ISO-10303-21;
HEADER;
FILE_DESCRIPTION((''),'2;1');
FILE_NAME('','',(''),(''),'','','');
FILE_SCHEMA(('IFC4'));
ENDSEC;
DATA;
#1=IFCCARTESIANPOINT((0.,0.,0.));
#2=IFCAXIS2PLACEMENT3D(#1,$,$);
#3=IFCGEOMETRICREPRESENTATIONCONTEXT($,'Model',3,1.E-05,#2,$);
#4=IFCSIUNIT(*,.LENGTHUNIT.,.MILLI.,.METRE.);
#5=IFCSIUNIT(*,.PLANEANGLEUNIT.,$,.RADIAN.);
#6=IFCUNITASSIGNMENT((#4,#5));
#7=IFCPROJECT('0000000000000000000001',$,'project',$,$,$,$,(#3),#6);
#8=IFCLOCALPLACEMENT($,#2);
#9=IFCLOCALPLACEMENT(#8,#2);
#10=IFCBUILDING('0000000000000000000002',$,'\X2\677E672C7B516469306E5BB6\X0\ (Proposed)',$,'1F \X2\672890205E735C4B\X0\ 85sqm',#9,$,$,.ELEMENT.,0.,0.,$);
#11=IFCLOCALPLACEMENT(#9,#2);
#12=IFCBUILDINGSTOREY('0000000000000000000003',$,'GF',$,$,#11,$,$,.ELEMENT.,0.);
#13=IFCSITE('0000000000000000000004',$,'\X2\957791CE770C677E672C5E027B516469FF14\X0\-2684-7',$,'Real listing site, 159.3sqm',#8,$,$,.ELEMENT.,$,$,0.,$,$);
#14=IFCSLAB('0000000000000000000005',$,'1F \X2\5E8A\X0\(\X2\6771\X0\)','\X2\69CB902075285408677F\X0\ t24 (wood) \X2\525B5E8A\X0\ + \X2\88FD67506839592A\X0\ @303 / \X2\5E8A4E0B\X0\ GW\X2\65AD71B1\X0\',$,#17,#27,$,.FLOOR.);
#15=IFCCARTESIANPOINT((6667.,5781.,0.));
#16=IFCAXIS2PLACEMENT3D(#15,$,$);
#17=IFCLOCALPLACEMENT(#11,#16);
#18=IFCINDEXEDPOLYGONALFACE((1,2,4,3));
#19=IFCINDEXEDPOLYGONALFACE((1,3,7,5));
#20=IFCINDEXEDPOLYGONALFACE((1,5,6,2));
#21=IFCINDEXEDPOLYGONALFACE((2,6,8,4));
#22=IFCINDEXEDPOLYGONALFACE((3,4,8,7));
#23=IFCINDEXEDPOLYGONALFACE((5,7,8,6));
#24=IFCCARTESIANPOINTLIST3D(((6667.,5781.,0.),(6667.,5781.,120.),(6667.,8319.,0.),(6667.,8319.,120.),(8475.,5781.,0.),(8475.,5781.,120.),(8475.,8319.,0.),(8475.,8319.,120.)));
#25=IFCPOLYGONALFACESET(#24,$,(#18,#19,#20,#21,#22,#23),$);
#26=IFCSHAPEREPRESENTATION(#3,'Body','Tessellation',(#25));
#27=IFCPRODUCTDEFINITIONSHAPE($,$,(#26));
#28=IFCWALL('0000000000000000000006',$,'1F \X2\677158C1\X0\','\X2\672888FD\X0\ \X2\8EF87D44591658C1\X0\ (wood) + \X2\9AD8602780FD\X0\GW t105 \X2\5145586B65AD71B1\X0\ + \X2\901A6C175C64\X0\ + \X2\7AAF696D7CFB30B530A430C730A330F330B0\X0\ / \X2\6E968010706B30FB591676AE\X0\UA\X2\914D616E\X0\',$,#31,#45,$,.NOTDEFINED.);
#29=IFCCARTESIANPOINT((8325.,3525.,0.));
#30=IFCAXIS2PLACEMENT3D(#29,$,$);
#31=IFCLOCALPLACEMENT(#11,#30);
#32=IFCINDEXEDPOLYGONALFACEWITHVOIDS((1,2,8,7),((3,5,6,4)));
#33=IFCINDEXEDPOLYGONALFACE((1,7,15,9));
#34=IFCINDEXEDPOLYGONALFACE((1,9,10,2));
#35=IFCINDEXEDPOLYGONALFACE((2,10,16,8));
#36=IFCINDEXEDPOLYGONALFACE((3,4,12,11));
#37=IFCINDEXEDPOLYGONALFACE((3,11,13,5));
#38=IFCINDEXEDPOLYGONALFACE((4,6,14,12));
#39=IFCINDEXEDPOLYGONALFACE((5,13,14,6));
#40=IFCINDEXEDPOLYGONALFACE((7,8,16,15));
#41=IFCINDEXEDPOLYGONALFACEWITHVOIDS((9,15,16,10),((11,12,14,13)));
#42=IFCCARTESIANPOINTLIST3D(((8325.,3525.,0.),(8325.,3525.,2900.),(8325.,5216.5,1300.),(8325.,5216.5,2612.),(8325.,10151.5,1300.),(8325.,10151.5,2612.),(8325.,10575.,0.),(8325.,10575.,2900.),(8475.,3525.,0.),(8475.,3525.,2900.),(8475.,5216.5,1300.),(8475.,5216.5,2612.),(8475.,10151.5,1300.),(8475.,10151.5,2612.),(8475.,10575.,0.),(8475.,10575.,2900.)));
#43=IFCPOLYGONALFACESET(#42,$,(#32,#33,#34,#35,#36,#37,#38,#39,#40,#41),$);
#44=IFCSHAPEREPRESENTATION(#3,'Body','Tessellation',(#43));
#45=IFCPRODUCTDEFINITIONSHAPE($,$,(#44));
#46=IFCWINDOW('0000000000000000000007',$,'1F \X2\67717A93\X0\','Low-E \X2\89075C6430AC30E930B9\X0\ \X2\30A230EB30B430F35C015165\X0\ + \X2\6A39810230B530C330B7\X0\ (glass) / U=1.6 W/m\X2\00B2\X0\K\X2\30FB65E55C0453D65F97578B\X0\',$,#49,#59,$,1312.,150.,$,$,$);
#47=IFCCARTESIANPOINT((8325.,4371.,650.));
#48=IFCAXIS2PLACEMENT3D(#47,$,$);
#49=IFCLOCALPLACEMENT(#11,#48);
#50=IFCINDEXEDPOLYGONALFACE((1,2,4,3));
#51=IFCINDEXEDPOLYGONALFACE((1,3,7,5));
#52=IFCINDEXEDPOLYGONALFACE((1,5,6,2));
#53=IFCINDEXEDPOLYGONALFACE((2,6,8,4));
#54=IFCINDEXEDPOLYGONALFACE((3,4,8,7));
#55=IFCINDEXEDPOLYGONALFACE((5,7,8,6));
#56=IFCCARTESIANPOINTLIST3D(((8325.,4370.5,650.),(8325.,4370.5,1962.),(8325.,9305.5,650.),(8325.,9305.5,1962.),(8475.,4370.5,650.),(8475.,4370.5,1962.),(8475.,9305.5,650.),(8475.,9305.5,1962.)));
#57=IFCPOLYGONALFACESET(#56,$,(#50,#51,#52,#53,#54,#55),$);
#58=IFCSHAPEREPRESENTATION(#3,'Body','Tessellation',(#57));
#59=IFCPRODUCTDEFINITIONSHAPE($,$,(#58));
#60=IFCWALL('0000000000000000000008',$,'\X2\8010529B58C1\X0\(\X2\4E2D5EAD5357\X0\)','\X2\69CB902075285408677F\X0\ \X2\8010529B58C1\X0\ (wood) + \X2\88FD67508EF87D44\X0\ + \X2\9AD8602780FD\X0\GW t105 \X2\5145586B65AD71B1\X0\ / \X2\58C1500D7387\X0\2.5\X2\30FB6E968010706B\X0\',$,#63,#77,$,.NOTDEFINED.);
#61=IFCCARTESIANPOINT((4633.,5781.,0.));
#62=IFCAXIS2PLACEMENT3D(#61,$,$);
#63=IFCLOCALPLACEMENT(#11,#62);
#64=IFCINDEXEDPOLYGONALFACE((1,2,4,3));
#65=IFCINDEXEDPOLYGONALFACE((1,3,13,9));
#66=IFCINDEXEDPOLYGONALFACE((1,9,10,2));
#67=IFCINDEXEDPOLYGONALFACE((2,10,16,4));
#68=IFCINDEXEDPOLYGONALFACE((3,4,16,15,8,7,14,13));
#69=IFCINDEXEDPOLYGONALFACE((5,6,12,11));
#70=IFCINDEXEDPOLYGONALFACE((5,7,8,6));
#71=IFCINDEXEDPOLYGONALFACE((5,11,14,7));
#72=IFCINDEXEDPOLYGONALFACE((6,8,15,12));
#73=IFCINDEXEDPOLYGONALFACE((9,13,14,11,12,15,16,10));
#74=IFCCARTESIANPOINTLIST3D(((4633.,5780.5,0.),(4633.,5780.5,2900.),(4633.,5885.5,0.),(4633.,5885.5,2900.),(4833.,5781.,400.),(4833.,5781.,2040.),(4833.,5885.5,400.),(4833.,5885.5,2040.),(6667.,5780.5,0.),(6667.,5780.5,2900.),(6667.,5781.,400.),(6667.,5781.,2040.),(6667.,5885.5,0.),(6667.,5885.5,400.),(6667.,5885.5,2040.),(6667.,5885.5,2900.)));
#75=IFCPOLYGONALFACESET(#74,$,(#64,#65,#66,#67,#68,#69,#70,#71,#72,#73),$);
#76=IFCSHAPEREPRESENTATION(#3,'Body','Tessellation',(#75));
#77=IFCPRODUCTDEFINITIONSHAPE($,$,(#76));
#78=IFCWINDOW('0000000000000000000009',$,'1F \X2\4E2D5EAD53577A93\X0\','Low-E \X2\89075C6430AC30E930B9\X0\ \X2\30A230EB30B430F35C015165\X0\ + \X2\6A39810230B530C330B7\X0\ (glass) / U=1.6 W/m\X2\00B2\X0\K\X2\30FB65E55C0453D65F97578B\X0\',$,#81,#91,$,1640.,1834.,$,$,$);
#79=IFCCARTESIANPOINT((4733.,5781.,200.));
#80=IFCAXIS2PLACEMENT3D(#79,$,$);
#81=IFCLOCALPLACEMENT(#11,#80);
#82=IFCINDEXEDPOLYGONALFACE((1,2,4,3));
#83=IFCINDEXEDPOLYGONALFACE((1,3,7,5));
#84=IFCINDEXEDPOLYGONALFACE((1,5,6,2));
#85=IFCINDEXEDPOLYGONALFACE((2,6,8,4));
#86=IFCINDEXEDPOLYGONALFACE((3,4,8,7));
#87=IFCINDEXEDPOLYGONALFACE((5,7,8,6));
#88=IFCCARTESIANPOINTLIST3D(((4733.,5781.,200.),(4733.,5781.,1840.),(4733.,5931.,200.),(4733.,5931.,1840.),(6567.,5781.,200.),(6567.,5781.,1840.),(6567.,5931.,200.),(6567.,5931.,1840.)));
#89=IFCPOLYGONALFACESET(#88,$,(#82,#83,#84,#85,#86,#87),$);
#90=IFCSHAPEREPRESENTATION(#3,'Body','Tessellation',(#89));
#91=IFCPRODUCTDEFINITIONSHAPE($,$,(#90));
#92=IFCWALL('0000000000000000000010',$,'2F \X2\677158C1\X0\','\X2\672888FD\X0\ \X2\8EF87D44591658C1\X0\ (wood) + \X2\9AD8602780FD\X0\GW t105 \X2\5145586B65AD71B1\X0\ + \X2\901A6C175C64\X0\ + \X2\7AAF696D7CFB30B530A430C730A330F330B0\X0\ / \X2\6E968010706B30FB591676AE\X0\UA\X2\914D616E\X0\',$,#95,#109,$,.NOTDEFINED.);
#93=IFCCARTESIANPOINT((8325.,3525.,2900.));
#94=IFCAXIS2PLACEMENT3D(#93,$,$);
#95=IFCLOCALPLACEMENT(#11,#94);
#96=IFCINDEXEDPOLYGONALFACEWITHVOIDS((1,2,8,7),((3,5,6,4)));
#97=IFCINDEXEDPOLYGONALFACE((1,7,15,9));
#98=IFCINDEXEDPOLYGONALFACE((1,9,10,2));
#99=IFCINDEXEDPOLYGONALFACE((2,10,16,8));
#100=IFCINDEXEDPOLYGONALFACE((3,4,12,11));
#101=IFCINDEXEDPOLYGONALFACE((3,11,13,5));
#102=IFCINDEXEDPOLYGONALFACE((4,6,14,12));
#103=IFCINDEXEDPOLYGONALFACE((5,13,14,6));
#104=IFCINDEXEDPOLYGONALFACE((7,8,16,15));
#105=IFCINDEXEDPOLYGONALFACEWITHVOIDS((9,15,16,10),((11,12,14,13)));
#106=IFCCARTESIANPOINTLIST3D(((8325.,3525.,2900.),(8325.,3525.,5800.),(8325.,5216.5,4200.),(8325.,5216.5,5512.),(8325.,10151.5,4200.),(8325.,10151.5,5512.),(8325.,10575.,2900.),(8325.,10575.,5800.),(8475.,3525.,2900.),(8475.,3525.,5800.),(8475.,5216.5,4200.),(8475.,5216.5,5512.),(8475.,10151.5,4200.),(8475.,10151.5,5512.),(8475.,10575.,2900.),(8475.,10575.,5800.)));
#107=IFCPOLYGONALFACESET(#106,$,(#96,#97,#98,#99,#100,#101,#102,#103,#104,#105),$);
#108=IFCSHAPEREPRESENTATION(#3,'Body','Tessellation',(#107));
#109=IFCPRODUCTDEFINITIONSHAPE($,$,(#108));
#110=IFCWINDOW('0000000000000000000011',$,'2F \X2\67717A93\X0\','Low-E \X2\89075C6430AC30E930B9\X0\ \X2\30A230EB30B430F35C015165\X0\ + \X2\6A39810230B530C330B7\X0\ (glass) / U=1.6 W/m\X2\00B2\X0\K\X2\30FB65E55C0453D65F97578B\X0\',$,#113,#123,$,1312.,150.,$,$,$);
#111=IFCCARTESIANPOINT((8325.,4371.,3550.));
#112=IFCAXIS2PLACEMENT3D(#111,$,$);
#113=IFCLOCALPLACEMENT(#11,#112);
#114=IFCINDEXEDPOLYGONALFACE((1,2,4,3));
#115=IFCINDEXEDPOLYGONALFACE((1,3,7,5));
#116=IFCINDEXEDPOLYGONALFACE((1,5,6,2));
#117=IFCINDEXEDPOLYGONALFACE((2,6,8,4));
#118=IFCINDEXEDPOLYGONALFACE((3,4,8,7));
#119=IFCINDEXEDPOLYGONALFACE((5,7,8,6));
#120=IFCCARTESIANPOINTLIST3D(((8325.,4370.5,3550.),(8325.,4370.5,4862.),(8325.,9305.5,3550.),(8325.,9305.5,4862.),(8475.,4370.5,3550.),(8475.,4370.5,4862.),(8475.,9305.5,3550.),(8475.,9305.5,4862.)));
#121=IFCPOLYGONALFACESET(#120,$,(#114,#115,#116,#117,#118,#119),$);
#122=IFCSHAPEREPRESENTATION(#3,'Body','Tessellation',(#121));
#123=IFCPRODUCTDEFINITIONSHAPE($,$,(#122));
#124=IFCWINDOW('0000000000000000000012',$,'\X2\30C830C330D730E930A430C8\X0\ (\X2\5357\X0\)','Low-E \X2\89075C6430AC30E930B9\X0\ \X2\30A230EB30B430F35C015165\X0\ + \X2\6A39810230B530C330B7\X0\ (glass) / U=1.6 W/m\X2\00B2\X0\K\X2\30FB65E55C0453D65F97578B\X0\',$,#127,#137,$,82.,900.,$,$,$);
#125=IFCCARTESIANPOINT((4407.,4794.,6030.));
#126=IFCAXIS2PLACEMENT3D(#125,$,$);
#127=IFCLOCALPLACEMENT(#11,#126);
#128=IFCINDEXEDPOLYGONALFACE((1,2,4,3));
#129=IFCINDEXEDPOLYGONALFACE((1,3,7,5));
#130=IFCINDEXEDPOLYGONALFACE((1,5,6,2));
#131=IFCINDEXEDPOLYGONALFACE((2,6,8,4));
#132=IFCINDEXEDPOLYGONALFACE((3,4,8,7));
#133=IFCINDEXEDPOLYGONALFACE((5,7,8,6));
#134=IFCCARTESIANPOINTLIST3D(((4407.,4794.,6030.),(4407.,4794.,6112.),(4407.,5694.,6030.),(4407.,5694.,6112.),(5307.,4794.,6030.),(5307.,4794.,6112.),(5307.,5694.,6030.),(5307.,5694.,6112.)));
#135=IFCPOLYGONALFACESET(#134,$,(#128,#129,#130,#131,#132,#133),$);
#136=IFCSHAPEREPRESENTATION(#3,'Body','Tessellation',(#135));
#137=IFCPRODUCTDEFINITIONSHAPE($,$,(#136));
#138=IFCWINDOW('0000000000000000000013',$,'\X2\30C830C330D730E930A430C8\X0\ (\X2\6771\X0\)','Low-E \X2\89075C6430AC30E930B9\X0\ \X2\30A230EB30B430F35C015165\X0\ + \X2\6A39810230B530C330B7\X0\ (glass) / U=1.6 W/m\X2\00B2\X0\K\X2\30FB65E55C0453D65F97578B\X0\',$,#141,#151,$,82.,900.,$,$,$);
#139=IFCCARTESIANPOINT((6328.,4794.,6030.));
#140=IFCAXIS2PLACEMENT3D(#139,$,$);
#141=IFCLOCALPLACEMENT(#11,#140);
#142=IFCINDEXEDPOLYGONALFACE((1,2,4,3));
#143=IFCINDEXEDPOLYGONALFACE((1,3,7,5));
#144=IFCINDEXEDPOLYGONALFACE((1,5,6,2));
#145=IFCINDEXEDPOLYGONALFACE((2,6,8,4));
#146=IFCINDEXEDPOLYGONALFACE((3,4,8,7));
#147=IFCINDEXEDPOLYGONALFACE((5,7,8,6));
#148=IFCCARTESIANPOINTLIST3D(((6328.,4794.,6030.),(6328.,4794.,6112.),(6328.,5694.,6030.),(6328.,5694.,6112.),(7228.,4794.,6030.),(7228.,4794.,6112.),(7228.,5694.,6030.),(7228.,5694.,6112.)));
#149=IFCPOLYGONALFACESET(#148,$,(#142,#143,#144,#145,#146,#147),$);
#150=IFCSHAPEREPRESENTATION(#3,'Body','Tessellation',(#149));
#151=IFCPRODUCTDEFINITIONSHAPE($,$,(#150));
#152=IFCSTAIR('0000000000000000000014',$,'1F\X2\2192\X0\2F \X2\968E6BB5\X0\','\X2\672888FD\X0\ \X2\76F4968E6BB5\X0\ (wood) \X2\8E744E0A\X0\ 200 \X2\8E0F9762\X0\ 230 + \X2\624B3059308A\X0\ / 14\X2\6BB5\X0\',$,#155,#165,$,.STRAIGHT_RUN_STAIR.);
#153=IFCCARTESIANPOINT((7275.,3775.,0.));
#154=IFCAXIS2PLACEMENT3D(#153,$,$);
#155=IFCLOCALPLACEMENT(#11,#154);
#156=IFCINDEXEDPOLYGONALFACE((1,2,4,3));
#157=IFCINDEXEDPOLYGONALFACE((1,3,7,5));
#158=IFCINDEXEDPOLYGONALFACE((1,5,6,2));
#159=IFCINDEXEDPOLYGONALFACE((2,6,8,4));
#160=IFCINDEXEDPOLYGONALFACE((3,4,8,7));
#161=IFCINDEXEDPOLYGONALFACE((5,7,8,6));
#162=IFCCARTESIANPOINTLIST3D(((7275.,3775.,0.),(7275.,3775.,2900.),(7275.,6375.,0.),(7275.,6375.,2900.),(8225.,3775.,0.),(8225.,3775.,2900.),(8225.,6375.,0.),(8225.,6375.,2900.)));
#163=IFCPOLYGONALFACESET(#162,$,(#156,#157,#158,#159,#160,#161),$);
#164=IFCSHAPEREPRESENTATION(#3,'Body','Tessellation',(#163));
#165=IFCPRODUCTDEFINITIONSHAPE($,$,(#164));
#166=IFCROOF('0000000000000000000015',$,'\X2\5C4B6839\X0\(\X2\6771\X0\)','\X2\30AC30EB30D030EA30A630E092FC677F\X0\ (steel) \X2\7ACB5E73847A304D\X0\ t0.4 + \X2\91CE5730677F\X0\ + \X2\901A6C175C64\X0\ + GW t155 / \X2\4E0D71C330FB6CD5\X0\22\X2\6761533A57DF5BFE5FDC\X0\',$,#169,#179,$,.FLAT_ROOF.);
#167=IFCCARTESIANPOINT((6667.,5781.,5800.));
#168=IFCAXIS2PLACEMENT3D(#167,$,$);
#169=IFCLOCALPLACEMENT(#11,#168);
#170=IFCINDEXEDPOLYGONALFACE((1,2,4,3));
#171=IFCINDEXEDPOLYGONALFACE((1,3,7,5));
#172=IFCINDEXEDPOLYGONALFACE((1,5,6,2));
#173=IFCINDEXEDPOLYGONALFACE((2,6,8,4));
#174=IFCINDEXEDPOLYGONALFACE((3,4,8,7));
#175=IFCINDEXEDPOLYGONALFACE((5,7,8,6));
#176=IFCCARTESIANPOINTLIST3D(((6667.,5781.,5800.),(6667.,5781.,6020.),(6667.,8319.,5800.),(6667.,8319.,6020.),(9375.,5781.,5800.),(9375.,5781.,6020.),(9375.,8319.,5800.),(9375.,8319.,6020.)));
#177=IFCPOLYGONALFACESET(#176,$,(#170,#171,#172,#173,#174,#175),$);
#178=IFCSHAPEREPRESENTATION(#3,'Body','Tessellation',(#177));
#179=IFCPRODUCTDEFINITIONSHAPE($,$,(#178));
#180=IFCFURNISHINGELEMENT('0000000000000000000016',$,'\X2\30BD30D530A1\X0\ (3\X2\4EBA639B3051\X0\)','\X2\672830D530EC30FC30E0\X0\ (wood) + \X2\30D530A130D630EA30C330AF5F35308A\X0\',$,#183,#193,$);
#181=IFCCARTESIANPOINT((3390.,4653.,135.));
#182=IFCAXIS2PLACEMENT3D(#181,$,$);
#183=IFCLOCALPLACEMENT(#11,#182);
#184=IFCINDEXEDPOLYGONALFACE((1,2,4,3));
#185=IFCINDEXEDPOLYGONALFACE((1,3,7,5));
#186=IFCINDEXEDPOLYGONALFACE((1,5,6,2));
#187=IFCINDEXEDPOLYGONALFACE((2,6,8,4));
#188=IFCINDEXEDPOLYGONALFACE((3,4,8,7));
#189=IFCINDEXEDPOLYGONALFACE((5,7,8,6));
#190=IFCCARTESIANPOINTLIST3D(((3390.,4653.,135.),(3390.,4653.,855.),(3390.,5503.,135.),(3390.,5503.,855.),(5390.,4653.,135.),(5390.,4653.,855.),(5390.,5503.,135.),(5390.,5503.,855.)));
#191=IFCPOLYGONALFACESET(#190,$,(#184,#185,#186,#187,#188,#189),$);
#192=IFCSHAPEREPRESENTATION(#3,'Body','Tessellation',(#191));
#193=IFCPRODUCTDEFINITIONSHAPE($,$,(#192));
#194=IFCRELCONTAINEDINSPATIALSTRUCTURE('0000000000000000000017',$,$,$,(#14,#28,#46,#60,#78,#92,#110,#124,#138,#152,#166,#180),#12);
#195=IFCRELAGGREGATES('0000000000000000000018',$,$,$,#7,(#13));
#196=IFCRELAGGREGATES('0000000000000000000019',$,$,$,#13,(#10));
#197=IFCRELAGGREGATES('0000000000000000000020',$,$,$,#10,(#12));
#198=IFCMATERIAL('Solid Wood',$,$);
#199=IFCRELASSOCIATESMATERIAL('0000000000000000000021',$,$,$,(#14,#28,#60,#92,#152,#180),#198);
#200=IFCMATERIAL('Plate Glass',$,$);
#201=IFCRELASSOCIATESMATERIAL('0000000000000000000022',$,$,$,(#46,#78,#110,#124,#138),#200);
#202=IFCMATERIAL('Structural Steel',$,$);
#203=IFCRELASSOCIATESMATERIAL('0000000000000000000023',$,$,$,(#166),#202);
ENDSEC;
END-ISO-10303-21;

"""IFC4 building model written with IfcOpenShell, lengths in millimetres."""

from ifc_helpers import new_model, si_unit, frame, frame_2d, origin, place, context, project, spatial, rectangle, extrude, material, element, fill, save


model = new_model("IFC4")

# Units and contexts
model_context = context("Model", 3, precision=1e-05, world=origin())
ifc_project = project(units=[si_unit("LENGTHUNIT", "METRE", prefix="MILLI"), si_unit("PLANEANGLEUNIT", "RADIAN")], contexts=[model_context])

# Site, building, storey
site_placement = place(None, origin())
site = spatial("IfcSite", under=ifc_project, at=site_placement, Name="長野県松本市筑摩４-2684-7", ObjectType="Real listing site, 159.3sqm", CompositionType="ELEMENT", RefElevation=0.0)
building_placement = place(site_placement, origin())
building = spatial("IfcBuilding", under=site, at=building_placement, Name="松本筑摩の家 (Proposed)", ObjectType="1F 木造平屋 85sqm", CompositionType="ELEMENT", ElevationOfRefHeight=0.0, ElevationOfTerrain=0.0)
storey_placement = place(building_placement, origin())
storey = spatial("IfcBuildingStorey", under=building, at=storey_placement, Name="GF", CompositionType="ELEMENT", Elevation=0.0)

# Slab
ifc_material_1 = material(Name="Solid Wood")
slab_placement = place(storey_placement, frame((6667.0, 5781.0, 0.0)))
element("IfcSlab", 1, at=slab_placement, inside=storey, material=ifc_material_1, Name="1F 床(東)", Description="構造用合板 t24 (wood) 剛床 + 製材根太 @303 / 床下 GW断熱", PredefinedType="FLOOR", context=model_context, shape_type="SweptSolid", body=[
    extrude(rectangle(XDim=1808.0, YDim=2538.0, at=frame_2d((904.0, 1269.0))), frame((6667.0, 5781.0, 0.0)), (0.0, 0.0, 1.0), 120.0),
])

# Walls, openings, windows
wall_1_placement = place(storey_placement, frame((8325.0, 3525.0, 0.0)))
wall_1 = element("IfcWall", 2, at=wall_1_placement, inside=storey, material=ifc_material_1, Name="1F 東壁", Description="木製 軸組外壁 (wood) + 高性能GW t105 充填断熱 + 通気層 + 窯業系サイディング / 準耐火・外皮UA配慮", PredefinedType="NOTDEFINED", context=model_context, shape_type="SweptSolid", body=[
    extrude(rectangle(XDim=150.0, YDim=7050.0, at=frame_2d((75.0, 3525.0))), frame((8325.0, 3525.0, 0.0)), (0.0, 0.0, 1.0), 2900.0),
])
opening_1_placement = place(storey_placement, frame((8325.0, 4371.0, 650.0)))
opening_1 = element("IfcOpeningElement", 3, at=opening_1_placement, cuts=wall_1, PredefinedType="NOTDEFINED", context=model_context, shape_type="SweptSolid", body=[
    extrude(rectangle(XDim=150.0, YDim=4935.0, at=frame_2d((75.0, 2467.0))), frame((8325.0, 4371.0, 650.0)), (0.0, 0.0, 1.0), 1312.0),
])
ifc_material_2 = material(Name="Plate Glass")
window_1_placement = place(storey_placement, frame((8325.0, 4371.0, 650.0)))
window_1 = element("IfcWindow", 4, at=window_1_placement, inside=storey, material=ifc_material_2, Name="1F 東窓", Description="Low-E 複層ガラス アルゴン封入 + 樹脂サッシ (glass) / U=1.6 W/m²K・日射取得型", OverallHeight=1312.0, OverallWidth=150.0, context=model_context, shape_type="SweptSolid", body=[
    extrude(rectangle(XDim=150.0, YDim=4935.0, at=frame_2d((75.0, 2467.0))), frame((8325.0, 4371.0, 650.0)), (0.0, 0.0, 1.0), 1312.0),
])
fill(opening_1, window_1)
wall_2_placement = place(storey_placement, frame((4633.0, 5781.0, 0.0)))
wall_2 = element("IfcWall", 5, at=wall_2_placement, inside=storey, material=ifc_material_1, Name="耐力壁(中庭南)", Description="構造用合板 耐力壁 (wood) + 製材軸組 + 高性能GW t105 充填断熱 / 壁倍率2.5・準耐火", PredefinedType="NOTDEFINED", context=model_context, shape_type="SweptSolid", body=[
    extrude(rectangle(XDim=2034.0, YDim=105.0, at=frame_2d((1017.0, 52.0))), frame((4633.0, 5781.0, 0.0)), (0.0, 0.0, 1.0), 2900.0),
])
opening_2_placement = place(storey_placement, frame((4733.0, 5781.0, 200.0)))
opening_2 = element("IfcOpeningElement", 6, at=opening_2_placement, cuts=wall_2, PredefinedType="NOTDEFINED", context=model_context, shape_type="SweptSolid", body=[
    extrude(rectangle(XDim=1834.0, YDim=150.0, at=frame_2d((917.0, 75.0))), frame((4733.0, 5781.0, 200.0)), (0.0, 0.0, 1.0), 1640.0),
])
window_2_placement = place(storey_placement, frame((4733.0, 5781.0, 200.0)))
window_2 = element("IfcWindow", 7, at=window_2_placement, inside=storey, material=ifc_material_2, Name="1F 中庭南窓", Description="Low-E 複層ガラス アルゴン封入 + 樹脂サッシ (glass) / U=1.6 W/m²K・日射取得型", OverallHeight=1640.0, OverallWidth=1834.0, context=model_context, shape_type="SweptSolid", body=[
    extrude(rectangle(XDim=1834.0, YDim=150.0, at=frame_2d((917.0, 75.0))), frame((4733.0, 5781.0, 200.0)), (0.0, 0.0, 1.0), 1640.0),
])
fill(opening_2, window_2)

# Wall, opening, window
wall_3_placement = place(storey_placement, frame((8325.0, 3525.0, 2900.0)))
wall_3 = element("IfcWall", 8, at=wall_3_placement, inside=storey, material=ifc_material_1, Name="2F 東壁", Description="木製 軸組外壁 (wood) + 高性能GW t105 充填断熱 + 通気層 + 窯業系サイディング / 準耐火・外皮UA配慮", PredefinedType="NOTDEFINED", context=model_context, shape_type="SweptSolid", body=[
    extrude(rectangle(XDim=150.0, YDim=7050.0, at=frame_2d((75.0, 3525.0))), frame((8325.0, 3525.0, 2900.0)), (0.0, 0.0, 1.0), 2900.0),
])
opening_3_placement = place(storey_placement, frame((8325.0, 4371.0, 3550.0)))
opening_3 = element("IfcOpeningElement", 9, at=opening_3_placement, cuts=wall_3, PredefinedType="NOTDEFINED", context=model_context, shape_type="SweptSolid", body=[
    extrude(rectangle(XDim=150.0, YDim=4935.0, at=frame_2d((75.0, 2467.0))), frame((8325.0, 4371.0, 3550.0)), (0.0, 0.0, 1.0), 1312.0),
])
window_3_placement = place(storey_placement, frame((8325.0, 4371.0, 3550.0)))
window_3 = element("IfcWindow", 10, at=window_3_placement, inside=storey, material=ifc_material_2, Name="2F 東窓", Description="Low-E 複層ガラス アルゴン封入 + 樹脂サッシ (glass) / U=1.6 W/m²K・日射取得型", OverallHeight=1312.0, OverallWidth=150.0, context=model_context, shape_type="SweptSolid", body=[
    extrude(rectangle(XDim=150.0, YDim=4935.0, at=frame_2d((75.0, 2467.0))), frame((8325.0, 4371.0, 3550.0)), (0.0, 0.0, 1.0), 1312.0),
])
fill(opening_3, window_3)

# Windows
window_4_placement = place(storey_placement, frame((4407.0, 4794.0, 6030.0)))
element("IfcWindow", 11, at=window_4_placement, inside=storey, material=ifc_material_2, Name="トップライト (南)", Description="Low-E 複層ガラス アルゴン封入 + 樹脂サッシ (glass) / U=1.6 W/m²K・日射取得型", OverallHeight=82.0, OverallWidth=900.0, context=model_context, shape_type="SweptSolid", body=[
    extrude(rectangle(XDim=900.0, YDim=900.0, at=frame_2d((450.0, 450.0))), frame((4407.0, 4794.0, 6030.0)), (0.0, 0.0, 1.0), 82.0),
])
window_5_placement = place(storey_placement, frame((6328.0, 4794.0, 6030.0)))
element("IfcWindow", 12, at=window_5_placement, inside=storey, material=ifc_material_2, Name="トップライト (東)", Description="Low-E 複層ガラス アルゴン封入 + 樹脂サッシ (glass) / U=1.6 W/m²K・日射取得型", OverallHeight=82.0, OverallWidth=900.0, context=model_context, shape_type="SweptSolid", body=[
    extrude(rectangle(XDim=900.0, YDim=900.0, at=frame_2d((450.0, 450.0))), frame((6328.0, 4794.0, 6030.0)), (0.0, 0.0, 1.0), 82.0),
])

# Stair
stair_placement = place(storey_placement, frame((7275.0, 3775.0, 0.0)))
element("IfcStair", 13, at=stair_placement, inside=storey, material=ifc_material_1, Name="1F→2F 階段", Description="木製 直階段 (wood) 蹴上 200 踏面 230 + 手すり / 14段", PredefinedType="STRAIGHT_RUN_STAIR", context=model_context, shape_type="SweptSolid", body=[
    extrude(rectangle(XDim=950.0, YDim=2600.0, at=frame_2d((475.0, 1300.0))), frame((7275.0, 3775.0, 0.0)), (0.0, 0.0, 1.0), 2900.0),
])

# Roof
ifc_material_3 = material(Name="Structural Steel")
roof_placement = place(storey_placement, frame((6667.0, 5781.0, 5800.0)))
element("IfcRoof", 14, at=roof_placement, inside=storey, material=ifc_material_3, Name="屋根(東)", Description="ガルバリウム鋼板 (steel) 立平葺き t0.4 + 野地板 + 通気層 + GW t155 / 不燃・法22条区域対応", PredefinedType="FLAT_ROOF", context=model_context, shape_type="SweptSolid", body=[
    extrude(rectangle(XDim=2708.0, YDim=2538.0, at=frame_2d((1354.0, 1269.0))), frame((6667.0, 5781.0, 5800.0)), (0.0, 0.0, 1.0), 220.0),
])

# Furnishing element
furnishing_1_placement = place(storey_placement, frame((3390.0, 4653.0, 135.0)))
element("IfcFurnishingElement", 15, at=furnishing_1_placement, inside=storey, material=ifc_material_1, Name="ソファ (3人掛け)", Description="木フレーム (wood) + ファブリック張り", context=model_context, shape_type="SweptSolid", body=[
    extrude(rectangle(XDim=2000.0, YDim=850.0, at=frame_2d((1000.0, 425.0))), frame((3390.0, 4653.0, 135.0)), (0.0, 0.0, 1.0), 720.0),
])

save(model, "model.ifc")
